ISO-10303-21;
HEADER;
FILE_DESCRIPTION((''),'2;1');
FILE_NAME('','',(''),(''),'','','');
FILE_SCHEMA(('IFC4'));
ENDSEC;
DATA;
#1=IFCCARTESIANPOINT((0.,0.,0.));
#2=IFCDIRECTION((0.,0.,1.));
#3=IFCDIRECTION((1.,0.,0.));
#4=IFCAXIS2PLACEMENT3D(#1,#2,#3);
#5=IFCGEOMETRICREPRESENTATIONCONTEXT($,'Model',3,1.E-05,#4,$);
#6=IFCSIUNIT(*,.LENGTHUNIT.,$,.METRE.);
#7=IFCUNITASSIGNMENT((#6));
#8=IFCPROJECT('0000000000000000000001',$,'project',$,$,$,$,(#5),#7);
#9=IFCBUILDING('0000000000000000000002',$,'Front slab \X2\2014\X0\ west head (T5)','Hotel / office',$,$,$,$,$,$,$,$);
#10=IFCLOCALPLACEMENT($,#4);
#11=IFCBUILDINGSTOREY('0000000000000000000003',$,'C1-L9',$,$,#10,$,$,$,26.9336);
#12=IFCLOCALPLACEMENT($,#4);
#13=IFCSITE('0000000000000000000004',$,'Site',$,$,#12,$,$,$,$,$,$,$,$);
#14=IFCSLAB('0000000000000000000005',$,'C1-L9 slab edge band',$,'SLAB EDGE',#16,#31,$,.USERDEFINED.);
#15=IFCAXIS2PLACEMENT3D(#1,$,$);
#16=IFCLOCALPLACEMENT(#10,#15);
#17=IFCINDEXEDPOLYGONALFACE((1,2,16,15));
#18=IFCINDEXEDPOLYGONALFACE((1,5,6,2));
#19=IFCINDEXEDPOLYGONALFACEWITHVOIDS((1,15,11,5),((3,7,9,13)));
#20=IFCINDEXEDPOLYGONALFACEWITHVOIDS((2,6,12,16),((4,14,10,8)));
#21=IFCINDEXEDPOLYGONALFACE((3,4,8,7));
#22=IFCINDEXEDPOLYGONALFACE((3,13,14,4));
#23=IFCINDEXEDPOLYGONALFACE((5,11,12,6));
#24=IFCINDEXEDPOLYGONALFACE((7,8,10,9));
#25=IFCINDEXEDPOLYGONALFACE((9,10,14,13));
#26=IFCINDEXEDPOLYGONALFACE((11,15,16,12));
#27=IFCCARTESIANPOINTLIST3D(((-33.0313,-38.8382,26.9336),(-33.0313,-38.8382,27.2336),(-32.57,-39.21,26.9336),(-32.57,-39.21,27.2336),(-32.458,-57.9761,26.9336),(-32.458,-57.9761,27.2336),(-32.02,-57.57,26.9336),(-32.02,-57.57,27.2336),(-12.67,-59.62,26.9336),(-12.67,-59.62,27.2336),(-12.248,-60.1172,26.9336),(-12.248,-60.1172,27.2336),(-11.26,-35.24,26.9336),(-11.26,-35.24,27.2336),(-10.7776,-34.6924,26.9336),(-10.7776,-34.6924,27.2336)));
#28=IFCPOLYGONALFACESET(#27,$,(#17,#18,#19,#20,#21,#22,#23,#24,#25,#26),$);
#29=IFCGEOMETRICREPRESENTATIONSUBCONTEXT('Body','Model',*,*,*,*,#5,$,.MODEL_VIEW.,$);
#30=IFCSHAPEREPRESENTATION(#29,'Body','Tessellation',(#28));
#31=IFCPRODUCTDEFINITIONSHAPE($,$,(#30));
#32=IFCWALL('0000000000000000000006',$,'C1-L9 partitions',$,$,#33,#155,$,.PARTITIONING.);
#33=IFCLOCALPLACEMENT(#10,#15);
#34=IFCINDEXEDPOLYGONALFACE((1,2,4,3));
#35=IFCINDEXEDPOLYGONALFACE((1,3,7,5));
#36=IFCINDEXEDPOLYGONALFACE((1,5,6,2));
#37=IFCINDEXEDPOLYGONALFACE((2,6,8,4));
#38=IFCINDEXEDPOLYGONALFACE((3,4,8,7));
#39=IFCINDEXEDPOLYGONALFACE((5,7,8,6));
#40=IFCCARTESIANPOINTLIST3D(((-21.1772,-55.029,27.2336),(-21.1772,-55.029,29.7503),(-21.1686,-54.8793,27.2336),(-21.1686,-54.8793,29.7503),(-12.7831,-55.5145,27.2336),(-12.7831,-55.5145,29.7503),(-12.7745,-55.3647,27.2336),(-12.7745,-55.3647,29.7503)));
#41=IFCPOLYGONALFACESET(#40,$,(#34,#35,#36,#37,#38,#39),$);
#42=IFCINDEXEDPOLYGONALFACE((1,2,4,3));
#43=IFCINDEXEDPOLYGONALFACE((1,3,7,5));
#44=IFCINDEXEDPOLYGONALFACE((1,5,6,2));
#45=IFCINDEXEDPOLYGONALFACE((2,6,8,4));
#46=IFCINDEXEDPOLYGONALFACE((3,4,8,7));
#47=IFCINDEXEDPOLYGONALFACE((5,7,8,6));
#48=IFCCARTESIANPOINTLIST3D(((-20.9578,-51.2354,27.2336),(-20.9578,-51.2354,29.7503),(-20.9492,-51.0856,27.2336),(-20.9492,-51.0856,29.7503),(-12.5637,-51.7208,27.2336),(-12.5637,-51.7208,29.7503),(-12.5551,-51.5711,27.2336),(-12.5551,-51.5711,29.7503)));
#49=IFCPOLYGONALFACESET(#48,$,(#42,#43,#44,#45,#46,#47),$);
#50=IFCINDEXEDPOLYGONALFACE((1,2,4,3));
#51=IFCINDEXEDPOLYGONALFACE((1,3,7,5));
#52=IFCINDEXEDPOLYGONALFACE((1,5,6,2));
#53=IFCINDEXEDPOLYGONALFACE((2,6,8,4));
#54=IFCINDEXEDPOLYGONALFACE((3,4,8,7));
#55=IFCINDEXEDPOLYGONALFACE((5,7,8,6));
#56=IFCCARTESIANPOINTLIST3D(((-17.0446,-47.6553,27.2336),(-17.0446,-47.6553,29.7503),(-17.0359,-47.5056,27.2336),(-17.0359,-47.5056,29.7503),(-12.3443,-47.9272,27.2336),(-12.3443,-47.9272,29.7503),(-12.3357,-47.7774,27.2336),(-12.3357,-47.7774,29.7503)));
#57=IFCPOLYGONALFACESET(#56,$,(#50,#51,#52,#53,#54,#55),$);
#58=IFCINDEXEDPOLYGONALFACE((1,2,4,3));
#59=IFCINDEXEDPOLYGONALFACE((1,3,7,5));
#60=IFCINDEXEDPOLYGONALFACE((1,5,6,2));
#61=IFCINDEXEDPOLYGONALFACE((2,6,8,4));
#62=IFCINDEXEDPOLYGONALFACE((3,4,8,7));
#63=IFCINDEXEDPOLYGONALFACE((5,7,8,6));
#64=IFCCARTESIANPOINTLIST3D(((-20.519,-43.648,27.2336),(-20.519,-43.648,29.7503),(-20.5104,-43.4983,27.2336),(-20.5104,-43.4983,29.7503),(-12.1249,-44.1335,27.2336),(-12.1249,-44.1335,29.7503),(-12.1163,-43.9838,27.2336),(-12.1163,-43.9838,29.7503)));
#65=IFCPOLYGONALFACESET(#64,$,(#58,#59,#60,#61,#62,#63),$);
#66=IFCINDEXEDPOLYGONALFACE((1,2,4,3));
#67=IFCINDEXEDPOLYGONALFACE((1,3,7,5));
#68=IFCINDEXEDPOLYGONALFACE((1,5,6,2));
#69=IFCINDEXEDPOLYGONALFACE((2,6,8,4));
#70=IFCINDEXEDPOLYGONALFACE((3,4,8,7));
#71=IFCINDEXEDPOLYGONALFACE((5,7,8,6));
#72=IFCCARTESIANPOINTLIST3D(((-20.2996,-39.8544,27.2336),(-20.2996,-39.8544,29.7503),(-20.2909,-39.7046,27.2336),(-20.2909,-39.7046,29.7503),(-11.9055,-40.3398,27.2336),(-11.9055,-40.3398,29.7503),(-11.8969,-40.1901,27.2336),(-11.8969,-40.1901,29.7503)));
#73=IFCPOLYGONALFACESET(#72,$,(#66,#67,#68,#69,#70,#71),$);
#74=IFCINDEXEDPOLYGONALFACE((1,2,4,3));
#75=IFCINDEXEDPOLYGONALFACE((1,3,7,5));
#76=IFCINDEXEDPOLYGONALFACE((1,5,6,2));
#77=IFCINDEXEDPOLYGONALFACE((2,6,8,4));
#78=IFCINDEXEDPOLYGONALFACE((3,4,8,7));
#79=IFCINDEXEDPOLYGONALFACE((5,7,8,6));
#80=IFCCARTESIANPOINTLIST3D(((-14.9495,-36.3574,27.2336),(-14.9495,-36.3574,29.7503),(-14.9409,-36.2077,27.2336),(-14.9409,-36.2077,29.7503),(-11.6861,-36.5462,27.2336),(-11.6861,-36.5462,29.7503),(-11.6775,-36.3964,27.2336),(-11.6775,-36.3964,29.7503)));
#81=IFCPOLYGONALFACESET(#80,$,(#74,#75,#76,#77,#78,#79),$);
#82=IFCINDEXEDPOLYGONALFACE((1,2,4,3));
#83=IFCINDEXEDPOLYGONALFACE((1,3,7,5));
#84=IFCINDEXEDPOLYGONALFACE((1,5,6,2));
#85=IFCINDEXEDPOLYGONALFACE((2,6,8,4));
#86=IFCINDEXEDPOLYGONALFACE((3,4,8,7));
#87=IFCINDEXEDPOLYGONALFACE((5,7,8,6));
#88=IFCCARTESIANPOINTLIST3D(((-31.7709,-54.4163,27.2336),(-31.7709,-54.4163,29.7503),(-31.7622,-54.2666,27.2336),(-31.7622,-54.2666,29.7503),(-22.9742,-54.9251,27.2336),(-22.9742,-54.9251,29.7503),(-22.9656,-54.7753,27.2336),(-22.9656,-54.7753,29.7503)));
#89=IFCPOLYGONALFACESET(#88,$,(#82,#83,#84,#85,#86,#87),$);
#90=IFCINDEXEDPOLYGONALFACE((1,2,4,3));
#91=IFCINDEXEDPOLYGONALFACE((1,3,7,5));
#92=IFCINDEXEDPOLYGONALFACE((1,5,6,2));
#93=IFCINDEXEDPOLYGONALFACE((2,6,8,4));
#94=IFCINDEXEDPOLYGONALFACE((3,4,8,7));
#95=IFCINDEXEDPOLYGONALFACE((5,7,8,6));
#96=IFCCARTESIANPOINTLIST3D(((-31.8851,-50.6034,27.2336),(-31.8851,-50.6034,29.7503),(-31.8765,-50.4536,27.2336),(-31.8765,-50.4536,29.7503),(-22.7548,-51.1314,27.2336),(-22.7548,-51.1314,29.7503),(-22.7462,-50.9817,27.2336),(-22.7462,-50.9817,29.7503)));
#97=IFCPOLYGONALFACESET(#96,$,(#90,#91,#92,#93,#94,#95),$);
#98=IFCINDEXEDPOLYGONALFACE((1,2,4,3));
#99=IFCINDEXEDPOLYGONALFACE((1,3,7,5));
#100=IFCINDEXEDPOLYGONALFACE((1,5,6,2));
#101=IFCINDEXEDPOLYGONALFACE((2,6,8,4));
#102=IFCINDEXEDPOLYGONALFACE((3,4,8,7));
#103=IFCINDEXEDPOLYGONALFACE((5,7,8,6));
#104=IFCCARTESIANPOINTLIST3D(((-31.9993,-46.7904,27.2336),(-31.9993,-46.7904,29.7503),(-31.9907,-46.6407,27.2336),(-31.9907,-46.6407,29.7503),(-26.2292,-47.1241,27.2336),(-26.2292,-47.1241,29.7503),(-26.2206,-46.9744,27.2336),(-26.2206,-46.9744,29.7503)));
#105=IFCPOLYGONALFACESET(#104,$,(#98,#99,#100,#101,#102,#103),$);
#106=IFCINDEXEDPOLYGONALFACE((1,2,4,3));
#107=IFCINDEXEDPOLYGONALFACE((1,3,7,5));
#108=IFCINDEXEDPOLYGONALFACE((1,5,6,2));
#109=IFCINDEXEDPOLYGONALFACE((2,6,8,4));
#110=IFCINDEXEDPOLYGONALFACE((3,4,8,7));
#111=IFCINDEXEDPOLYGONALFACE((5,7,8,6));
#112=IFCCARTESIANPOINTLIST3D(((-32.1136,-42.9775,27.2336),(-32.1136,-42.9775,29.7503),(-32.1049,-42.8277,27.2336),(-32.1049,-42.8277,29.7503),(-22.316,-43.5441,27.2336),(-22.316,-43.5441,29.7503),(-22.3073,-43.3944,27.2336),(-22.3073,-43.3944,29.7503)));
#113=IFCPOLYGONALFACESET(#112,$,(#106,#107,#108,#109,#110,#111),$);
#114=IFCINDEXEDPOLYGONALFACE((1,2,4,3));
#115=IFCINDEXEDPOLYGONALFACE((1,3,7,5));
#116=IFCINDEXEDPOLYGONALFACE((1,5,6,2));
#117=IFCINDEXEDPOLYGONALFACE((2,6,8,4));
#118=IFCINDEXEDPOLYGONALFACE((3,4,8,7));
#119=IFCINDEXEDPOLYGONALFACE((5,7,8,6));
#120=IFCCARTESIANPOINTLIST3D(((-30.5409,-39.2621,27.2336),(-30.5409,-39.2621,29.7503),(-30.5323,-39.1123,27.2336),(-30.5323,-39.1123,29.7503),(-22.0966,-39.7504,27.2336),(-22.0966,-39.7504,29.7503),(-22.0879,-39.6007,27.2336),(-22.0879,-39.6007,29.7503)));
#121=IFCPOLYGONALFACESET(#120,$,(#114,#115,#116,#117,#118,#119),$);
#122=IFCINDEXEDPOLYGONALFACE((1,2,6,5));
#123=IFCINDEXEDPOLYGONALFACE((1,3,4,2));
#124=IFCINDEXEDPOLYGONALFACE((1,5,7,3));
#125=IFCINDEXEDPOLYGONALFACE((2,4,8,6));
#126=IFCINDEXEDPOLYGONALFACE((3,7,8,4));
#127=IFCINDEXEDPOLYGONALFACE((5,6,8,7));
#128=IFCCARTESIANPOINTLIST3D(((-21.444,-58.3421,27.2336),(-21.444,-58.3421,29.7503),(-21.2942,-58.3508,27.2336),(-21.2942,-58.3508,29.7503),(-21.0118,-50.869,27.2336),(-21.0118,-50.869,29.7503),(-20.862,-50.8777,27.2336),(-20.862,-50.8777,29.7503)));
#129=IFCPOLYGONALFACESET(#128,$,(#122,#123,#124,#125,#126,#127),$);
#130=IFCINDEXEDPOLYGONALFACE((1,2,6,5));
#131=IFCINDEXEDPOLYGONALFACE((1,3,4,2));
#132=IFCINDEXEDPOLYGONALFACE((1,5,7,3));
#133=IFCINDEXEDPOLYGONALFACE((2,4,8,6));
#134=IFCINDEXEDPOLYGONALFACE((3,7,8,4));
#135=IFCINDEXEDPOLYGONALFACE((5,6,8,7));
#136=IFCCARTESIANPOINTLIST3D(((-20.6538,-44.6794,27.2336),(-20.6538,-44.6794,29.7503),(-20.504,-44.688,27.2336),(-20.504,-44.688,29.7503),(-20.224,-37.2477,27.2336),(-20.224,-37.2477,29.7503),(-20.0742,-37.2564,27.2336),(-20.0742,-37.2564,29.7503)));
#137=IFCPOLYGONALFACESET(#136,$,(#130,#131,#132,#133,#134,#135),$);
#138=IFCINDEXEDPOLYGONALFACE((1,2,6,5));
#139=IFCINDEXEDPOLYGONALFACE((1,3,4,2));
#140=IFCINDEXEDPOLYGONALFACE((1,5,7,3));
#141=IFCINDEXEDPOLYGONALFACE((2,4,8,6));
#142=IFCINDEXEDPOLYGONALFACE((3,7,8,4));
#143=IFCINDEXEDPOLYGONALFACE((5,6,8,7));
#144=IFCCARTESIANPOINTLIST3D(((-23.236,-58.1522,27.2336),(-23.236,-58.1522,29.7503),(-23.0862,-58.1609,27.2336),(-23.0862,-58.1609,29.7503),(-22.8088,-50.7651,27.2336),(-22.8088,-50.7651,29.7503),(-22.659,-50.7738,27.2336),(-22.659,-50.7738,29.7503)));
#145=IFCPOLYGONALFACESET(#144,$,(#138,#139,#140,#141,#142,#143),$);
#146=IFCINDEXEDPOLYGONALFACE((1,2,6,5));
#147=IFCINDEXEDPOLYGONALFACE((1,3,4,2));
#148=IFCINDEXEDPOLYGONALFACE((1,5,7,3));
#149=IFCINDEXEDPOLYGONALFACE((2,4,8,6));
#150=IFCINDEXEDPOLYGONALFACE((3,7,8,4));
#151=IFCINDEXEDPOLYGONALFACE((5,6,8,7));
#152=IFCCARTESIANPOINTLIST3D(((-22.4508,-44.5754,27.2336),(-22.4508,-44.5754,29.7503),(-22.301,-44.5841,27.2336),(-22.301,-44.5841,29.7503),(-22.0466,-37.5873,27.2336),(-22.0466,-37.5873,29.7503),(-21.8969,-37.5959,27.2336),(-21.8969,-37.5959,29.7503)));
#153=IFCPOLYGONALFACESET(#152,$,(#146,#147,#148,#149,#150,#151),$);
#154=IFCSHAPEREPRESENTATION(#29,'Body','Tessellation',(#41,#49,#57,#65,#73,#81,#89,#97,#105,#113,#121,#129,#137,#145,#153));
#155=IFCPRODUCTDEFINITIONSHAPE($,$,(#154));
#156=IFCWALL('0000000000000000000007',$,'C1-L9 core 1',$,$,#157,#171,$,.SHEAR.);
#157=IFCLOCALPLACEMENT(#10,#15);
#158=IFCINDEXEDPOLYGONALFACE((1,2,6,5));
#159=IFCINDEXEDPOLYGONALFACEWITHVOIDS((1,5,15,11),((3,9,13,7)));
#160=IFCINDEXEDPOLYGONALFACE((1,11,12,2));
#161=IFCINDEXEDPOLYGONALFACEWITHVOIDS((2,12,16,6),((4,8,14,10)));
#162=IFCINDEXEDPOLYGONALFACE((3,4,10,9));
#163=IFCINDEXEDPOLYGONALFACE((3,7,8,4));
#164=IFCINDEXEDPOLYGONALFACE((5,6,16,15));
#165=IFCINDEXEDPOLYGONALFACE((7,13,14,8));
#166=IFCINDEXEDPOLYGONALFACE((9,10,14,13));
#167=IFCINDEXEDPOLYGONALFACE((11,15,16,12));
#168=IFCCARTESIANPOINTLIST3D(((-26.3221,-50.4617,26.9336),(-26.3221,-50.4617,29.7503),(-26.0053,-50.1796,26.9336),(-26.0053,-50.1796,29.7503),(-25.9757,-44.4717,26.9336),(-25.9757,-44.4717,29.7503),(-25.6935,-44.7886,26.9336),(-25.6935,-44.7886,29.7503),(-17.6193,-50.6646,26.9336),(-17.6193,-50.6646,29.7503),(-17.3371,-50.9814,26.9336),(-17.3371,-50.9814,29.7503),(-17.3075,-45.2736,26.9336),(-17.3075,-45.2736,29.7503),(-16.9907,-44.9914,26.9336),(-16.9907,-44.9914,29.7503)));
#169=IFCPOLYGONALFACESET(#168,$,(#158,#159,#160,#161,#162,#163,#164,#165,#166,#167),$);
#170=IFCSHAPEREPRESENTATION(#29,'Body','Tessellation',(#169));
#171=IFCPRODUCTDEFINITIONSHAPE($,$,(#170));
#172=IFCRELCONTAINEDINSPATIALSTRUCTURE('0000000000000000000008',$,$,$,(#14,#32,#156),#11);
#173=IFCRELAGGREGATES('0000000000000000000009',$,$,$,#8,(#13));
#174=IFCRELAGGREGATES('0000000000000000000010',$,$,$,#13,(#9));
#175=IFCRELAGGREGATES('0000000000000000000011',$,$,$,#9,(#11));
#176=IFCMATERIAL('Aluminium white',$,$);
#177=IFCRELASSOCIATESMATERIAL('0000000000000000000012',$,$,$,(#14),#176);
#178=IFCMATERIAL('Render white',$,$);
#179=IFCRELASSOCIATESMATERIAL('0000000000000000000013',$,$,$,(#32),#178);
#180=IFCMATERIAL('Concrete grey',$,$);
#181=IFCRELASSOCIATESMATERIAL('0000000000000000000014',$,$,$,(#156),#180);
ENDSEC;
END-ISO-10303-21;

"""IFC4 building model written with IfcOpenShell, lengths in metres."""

from ifc_helpers import new_model, si_unit, frame, origin_with_axes, place, context, subcontext, project, spatial, polyline, outline, extrude, material, element, save


model = new_model("IFC4")

# Units and contexts
model_context = context("Model", 3, precision=1e-05, world=origin_with_axes())
body_context = subcontext(model_context, "Body", "Model", "MODEL_VIEW")
ifc_project = project(units=[si_unit("LENGTHUNIT", "METRE")], contexts=[model_context])

# Site, building, storey
site_placement = place(None, origin_with_axes())
site = spatial("IfcSite", under=ifc_project, at=site_placement, Name="Site")
building = spatial("IfcBuilding", under=site, Name="Front slab — west head (T5)", Description="Hotel / office")
storey_placement = place(None, origin_with_axes())
storey = spatial("IfcBuildingStorey", under=building, at=storey_placement, Name="C1-L9", Elevation=26.9336)

# Shared definitions
ifc_material_1 = material(Name="Aluminium white")

# Slab
slab_placement = place(storey_placement, origin_with_axes())
element("IfcSlab", 1, at=slab_placement, inside=storey, material=ifc_material_1, Name="C1-L9 slab edge band", ObjectType="SLAB EDGE", PredefinedType="USERDEFINED", context=body_context, shape_type="SweptSolid", body=[
    extrude(outline(polyline([(-33.0313, -38.8382), (-32.458, -57.9761), (-12.248, -60.1172), (-10.7776, -34.6924), (-33.0313, -38.8382)]), holes=[polyline([(-32.57, -39.21), (-32.02, -57.57), (-12.67, -59.62), (-11.26, -35.24), (-32.57, -39.21)])]), frame((0.0, 0.0, 26.9336), z_axis=(0.0, 0.0, 1.0), x_axis=(1.0, 0.0, 0.0)), (0.0, 0.0, 1.0), 0.3),
])

# Walls
ifc_material_2 = material(Name="Render white")
wall_1_placement = place(storey_placement, origin_with_axes())
element("IfcWall", 2, at=wall_1_placement, inside=storey, material=ifc_material_2, Name="C1-L9 partitions", PredefinedType="PARTITIONING", context=body_context, shape_type="SweptSolid", body=[
    extrude(outline(polyline([(-12.7745, -55.3647), (-21.1686, -54.8793), (-21.1772, -55.029), (-12.7831, -55.5145), (-12.7745, -55.3647)])), frame((0.0, 0.0, 27.2336), z_axis=(0.0, 0.0, 1.0), x_axis=(1.0, 0.0, 0.0)), (0.0, 0.0, 1.0), 2.5167),
    extrude(outline(polyline([(-12.5551, -51.5711), (-20.9492, -51.0856), (-20.9578, -51.2354), (-12.5637, -51.7208), (-12.5551, -51.5711)])), frame((0.0, 0.0, 27.2336), z_axis=(0.0, 0.0, 1.0), x_axis=(1.0, 0.0, 0.0)), (0.0, 0.0, 1.0), 2.5167),
    extrude(outline(polyline([(-12.3357, -47.7774), (-17.0359, -47.5056), (-17.0446, -47.6553), (-12.3443, -47.9272), (-12.3357, -47.7774)])), frame((0.0, 0.0, 27.2336), z_axis=(0.0, 0.0, 1.0), x_axis=(1.0, 0.0, 0.0)), (0.0, 0.0, 1.0), 2.5167),
    extrude(outline(polyline([(-12.1163, -43.9838), (-20.5104, -43.4983), (-20.519, -43.648), (-12.1249, -44.1335), (-12.1163, -43.9838)])), frame((0.0, 0.0, 27.2336), z_axis=(0.0, 0.0, 1.0), x_axis=(1.0, 0.0, 0.0)), (0.0, 0.0, 1.0), 2.5167),
    extrude(outline(polyline([(-11.8969, -40.1901), (-20.2909, -39.7046), (-20.2996, -39.8544), (-11.9055, -40.3398), (-11.8969, -40.1901)])), frame((0.0, 0.0, 27.2336), z_axis=(0.0, 0.0, 1.0), x_axis=(1.0, 0.0, 0.0)), (0.0, 0.0, 1.0), 2.5167),
    extrude(outline(polyline([(-11.6775, -36.3964), (-14.9409, -36.2077), (-14.9495, -36.3574), (-11.6861, -36.5462), (-11.6775, -36.3964)])), frame((0.0, 0.0, 27.2336), z_axis=(0.0, 0.0, 1.0), x_axis=(1.0, 0.0, 0.0)), (0.0, 0.0, 1.0), 2.5167),
    extrude(outline(polyline([(-22.9656, -54.7753), (-31.7622, -54.2666), (-31.7709, -54.4163), (-22.9742, -54.9251), (-22.9656, -54.7753)])), frame((0.0, 0.0, 27.2336), z_axis=(0.0, 0.0, 1.0), x_axis=(1.0, 0.0, 0.0)), (0.0, 0.0, 1.0), 2.5167),
    extrude(outline(polyline([(-22.7462, -50.9817), (-31.8765, -50.4536), (-31.8851, -50.6034), (-22.7548, -51.1314), (-22.7462, -50.9817)])), frame((0.0, 0.0, 27.2336), z_axis=(0.0, 0.0, 1.0), x_axis=(1.0, 0.0, 0.0)), (0.0, 0.0, 1.0), 2.5167),
    extrude(outline(polyline([(-26.2206, -46.9744), (-31.9907, -46.6407), (-31.9993, -46.7904), (-26.2292, -47.1241), (-26.2206, -46.9744)])), frame((0.0, 0.0, 27.2336), z_axis=(0.0, 0.0, 1.0), x_axis=(1.0, 0.0, 0.0)), (0.0, 0.0, 1.0), 2.5167),
    extrude(outline(polyline([(-22.3073, -43.3944), (-32.1049, -42.8277), (-32.1136, -42.9775), (-22.316, -43.5441), (-22.3073, -43.3944)])), frame((0.0, 0.0, 27.2336), z_axis=(0.0, 0.0, 1.0), x_axis=(1.0, 0.0, 0.0)), (0.0, 0.0, 1.0), 2.5167),
    extrude(outline(polyline([(-22.0879, -39.6007), (-30.5323, -39.1123), (-30.5409, -39.2621), (-22.0966, -39.7504), (-22.0879, -39.6007)])), frame((0.0, 0.0, 27.2336), z_axis=(0.0, 0.0, 1.0), x_axis=(1.0, 0.0, 0.0)), (0.0, 0.0, 1.0), 2.5167),
    extrude(outline(polyline([(-21.2942, -58.3508), (-20.862, -50.8777), (-21.0118, -50.869), (-21.444, -58.3421), (-21.2942, -58.3508)])), frame((0.0, 0.0, 27.2336), z_axis=(0.0, 0.0, 1.0), x_axis=(1.0, 0.0, 0.0)), (0.0, 0.0, 1.0), 2.5167),
    extrude(outline(polyline([(-20.504, -44.688), (-20.0742, -37.2564), (-20.224, -37.2477), (-20.6538, -44.6794), (-20.504, -44.688)])), frame((0.0, 0.0, 27.2336), z_axis=(0.0, 0.0, 1.0), x_axis=(1.0, 0.0, 0.0)), (0.0, 0.0, 1.0), 2.5167),
    extrude(outline(polyline([(-23.0862, -58.1609), (-22.659, -50.7738), (-22.8088, -50.7651), (-23.236, -58.1522), (-23.0862, -58.1609)])), frame((0.0, 0.0, 27.2336), z_axis=(0.0, 0.0, 1.0), x_axis=(1.0, 0.0, 0.0)), (0.0, 0.0, 1.0), 2.5167),
    extrude(outline(polyline([(-22.301, -44.5841), (-21.8969, -37.5959), (-22.0466, -37.5873), (-22.4508, -44.5754), (-22.301, -44.5841)])), frame((0.0, 0.0, 27.2336), z_axis=(0.0, 0.0, 1.0), x_axis=(1.0, 0.0, 0.0)), (0.0, 0.0, 1.0), 2.5167),
])
ifc_material_3 = material(Name="Concrete grey")
wall_2_placement = place(storey_placement, origin_with_axes())
element("IfcWall", 3, at=wall_2_placement, inside=storey, material=ifc_material_3, Name="C1-L9 core 1", PredefinedType="SHEAR", context=body_context, shape_type="SweptSolid", body=[
    extrude(outline(polyline([(-17.3371, -50.9814), (-16.9907, -44.9914), (-25.9757, -44.4717), (-26.3221, -50.4617), (-17.3371, -50.9814)]), holes=[polyline([(-17.6193, -50.6646), (-17.3075, -45.2736), (-25.6935, -44.7886), (-26.0053, -50.1796), (-17.6193, -50.6646)])]), frame((0.0, 0.0, 26.9336), z_axis=(0.0, 0.0, 1.0), x_axis=(1.0, 0.0, 0.0)), (0.0, 0.0, 1.0), 2.8167),
])

save(model, "model.ifc")
